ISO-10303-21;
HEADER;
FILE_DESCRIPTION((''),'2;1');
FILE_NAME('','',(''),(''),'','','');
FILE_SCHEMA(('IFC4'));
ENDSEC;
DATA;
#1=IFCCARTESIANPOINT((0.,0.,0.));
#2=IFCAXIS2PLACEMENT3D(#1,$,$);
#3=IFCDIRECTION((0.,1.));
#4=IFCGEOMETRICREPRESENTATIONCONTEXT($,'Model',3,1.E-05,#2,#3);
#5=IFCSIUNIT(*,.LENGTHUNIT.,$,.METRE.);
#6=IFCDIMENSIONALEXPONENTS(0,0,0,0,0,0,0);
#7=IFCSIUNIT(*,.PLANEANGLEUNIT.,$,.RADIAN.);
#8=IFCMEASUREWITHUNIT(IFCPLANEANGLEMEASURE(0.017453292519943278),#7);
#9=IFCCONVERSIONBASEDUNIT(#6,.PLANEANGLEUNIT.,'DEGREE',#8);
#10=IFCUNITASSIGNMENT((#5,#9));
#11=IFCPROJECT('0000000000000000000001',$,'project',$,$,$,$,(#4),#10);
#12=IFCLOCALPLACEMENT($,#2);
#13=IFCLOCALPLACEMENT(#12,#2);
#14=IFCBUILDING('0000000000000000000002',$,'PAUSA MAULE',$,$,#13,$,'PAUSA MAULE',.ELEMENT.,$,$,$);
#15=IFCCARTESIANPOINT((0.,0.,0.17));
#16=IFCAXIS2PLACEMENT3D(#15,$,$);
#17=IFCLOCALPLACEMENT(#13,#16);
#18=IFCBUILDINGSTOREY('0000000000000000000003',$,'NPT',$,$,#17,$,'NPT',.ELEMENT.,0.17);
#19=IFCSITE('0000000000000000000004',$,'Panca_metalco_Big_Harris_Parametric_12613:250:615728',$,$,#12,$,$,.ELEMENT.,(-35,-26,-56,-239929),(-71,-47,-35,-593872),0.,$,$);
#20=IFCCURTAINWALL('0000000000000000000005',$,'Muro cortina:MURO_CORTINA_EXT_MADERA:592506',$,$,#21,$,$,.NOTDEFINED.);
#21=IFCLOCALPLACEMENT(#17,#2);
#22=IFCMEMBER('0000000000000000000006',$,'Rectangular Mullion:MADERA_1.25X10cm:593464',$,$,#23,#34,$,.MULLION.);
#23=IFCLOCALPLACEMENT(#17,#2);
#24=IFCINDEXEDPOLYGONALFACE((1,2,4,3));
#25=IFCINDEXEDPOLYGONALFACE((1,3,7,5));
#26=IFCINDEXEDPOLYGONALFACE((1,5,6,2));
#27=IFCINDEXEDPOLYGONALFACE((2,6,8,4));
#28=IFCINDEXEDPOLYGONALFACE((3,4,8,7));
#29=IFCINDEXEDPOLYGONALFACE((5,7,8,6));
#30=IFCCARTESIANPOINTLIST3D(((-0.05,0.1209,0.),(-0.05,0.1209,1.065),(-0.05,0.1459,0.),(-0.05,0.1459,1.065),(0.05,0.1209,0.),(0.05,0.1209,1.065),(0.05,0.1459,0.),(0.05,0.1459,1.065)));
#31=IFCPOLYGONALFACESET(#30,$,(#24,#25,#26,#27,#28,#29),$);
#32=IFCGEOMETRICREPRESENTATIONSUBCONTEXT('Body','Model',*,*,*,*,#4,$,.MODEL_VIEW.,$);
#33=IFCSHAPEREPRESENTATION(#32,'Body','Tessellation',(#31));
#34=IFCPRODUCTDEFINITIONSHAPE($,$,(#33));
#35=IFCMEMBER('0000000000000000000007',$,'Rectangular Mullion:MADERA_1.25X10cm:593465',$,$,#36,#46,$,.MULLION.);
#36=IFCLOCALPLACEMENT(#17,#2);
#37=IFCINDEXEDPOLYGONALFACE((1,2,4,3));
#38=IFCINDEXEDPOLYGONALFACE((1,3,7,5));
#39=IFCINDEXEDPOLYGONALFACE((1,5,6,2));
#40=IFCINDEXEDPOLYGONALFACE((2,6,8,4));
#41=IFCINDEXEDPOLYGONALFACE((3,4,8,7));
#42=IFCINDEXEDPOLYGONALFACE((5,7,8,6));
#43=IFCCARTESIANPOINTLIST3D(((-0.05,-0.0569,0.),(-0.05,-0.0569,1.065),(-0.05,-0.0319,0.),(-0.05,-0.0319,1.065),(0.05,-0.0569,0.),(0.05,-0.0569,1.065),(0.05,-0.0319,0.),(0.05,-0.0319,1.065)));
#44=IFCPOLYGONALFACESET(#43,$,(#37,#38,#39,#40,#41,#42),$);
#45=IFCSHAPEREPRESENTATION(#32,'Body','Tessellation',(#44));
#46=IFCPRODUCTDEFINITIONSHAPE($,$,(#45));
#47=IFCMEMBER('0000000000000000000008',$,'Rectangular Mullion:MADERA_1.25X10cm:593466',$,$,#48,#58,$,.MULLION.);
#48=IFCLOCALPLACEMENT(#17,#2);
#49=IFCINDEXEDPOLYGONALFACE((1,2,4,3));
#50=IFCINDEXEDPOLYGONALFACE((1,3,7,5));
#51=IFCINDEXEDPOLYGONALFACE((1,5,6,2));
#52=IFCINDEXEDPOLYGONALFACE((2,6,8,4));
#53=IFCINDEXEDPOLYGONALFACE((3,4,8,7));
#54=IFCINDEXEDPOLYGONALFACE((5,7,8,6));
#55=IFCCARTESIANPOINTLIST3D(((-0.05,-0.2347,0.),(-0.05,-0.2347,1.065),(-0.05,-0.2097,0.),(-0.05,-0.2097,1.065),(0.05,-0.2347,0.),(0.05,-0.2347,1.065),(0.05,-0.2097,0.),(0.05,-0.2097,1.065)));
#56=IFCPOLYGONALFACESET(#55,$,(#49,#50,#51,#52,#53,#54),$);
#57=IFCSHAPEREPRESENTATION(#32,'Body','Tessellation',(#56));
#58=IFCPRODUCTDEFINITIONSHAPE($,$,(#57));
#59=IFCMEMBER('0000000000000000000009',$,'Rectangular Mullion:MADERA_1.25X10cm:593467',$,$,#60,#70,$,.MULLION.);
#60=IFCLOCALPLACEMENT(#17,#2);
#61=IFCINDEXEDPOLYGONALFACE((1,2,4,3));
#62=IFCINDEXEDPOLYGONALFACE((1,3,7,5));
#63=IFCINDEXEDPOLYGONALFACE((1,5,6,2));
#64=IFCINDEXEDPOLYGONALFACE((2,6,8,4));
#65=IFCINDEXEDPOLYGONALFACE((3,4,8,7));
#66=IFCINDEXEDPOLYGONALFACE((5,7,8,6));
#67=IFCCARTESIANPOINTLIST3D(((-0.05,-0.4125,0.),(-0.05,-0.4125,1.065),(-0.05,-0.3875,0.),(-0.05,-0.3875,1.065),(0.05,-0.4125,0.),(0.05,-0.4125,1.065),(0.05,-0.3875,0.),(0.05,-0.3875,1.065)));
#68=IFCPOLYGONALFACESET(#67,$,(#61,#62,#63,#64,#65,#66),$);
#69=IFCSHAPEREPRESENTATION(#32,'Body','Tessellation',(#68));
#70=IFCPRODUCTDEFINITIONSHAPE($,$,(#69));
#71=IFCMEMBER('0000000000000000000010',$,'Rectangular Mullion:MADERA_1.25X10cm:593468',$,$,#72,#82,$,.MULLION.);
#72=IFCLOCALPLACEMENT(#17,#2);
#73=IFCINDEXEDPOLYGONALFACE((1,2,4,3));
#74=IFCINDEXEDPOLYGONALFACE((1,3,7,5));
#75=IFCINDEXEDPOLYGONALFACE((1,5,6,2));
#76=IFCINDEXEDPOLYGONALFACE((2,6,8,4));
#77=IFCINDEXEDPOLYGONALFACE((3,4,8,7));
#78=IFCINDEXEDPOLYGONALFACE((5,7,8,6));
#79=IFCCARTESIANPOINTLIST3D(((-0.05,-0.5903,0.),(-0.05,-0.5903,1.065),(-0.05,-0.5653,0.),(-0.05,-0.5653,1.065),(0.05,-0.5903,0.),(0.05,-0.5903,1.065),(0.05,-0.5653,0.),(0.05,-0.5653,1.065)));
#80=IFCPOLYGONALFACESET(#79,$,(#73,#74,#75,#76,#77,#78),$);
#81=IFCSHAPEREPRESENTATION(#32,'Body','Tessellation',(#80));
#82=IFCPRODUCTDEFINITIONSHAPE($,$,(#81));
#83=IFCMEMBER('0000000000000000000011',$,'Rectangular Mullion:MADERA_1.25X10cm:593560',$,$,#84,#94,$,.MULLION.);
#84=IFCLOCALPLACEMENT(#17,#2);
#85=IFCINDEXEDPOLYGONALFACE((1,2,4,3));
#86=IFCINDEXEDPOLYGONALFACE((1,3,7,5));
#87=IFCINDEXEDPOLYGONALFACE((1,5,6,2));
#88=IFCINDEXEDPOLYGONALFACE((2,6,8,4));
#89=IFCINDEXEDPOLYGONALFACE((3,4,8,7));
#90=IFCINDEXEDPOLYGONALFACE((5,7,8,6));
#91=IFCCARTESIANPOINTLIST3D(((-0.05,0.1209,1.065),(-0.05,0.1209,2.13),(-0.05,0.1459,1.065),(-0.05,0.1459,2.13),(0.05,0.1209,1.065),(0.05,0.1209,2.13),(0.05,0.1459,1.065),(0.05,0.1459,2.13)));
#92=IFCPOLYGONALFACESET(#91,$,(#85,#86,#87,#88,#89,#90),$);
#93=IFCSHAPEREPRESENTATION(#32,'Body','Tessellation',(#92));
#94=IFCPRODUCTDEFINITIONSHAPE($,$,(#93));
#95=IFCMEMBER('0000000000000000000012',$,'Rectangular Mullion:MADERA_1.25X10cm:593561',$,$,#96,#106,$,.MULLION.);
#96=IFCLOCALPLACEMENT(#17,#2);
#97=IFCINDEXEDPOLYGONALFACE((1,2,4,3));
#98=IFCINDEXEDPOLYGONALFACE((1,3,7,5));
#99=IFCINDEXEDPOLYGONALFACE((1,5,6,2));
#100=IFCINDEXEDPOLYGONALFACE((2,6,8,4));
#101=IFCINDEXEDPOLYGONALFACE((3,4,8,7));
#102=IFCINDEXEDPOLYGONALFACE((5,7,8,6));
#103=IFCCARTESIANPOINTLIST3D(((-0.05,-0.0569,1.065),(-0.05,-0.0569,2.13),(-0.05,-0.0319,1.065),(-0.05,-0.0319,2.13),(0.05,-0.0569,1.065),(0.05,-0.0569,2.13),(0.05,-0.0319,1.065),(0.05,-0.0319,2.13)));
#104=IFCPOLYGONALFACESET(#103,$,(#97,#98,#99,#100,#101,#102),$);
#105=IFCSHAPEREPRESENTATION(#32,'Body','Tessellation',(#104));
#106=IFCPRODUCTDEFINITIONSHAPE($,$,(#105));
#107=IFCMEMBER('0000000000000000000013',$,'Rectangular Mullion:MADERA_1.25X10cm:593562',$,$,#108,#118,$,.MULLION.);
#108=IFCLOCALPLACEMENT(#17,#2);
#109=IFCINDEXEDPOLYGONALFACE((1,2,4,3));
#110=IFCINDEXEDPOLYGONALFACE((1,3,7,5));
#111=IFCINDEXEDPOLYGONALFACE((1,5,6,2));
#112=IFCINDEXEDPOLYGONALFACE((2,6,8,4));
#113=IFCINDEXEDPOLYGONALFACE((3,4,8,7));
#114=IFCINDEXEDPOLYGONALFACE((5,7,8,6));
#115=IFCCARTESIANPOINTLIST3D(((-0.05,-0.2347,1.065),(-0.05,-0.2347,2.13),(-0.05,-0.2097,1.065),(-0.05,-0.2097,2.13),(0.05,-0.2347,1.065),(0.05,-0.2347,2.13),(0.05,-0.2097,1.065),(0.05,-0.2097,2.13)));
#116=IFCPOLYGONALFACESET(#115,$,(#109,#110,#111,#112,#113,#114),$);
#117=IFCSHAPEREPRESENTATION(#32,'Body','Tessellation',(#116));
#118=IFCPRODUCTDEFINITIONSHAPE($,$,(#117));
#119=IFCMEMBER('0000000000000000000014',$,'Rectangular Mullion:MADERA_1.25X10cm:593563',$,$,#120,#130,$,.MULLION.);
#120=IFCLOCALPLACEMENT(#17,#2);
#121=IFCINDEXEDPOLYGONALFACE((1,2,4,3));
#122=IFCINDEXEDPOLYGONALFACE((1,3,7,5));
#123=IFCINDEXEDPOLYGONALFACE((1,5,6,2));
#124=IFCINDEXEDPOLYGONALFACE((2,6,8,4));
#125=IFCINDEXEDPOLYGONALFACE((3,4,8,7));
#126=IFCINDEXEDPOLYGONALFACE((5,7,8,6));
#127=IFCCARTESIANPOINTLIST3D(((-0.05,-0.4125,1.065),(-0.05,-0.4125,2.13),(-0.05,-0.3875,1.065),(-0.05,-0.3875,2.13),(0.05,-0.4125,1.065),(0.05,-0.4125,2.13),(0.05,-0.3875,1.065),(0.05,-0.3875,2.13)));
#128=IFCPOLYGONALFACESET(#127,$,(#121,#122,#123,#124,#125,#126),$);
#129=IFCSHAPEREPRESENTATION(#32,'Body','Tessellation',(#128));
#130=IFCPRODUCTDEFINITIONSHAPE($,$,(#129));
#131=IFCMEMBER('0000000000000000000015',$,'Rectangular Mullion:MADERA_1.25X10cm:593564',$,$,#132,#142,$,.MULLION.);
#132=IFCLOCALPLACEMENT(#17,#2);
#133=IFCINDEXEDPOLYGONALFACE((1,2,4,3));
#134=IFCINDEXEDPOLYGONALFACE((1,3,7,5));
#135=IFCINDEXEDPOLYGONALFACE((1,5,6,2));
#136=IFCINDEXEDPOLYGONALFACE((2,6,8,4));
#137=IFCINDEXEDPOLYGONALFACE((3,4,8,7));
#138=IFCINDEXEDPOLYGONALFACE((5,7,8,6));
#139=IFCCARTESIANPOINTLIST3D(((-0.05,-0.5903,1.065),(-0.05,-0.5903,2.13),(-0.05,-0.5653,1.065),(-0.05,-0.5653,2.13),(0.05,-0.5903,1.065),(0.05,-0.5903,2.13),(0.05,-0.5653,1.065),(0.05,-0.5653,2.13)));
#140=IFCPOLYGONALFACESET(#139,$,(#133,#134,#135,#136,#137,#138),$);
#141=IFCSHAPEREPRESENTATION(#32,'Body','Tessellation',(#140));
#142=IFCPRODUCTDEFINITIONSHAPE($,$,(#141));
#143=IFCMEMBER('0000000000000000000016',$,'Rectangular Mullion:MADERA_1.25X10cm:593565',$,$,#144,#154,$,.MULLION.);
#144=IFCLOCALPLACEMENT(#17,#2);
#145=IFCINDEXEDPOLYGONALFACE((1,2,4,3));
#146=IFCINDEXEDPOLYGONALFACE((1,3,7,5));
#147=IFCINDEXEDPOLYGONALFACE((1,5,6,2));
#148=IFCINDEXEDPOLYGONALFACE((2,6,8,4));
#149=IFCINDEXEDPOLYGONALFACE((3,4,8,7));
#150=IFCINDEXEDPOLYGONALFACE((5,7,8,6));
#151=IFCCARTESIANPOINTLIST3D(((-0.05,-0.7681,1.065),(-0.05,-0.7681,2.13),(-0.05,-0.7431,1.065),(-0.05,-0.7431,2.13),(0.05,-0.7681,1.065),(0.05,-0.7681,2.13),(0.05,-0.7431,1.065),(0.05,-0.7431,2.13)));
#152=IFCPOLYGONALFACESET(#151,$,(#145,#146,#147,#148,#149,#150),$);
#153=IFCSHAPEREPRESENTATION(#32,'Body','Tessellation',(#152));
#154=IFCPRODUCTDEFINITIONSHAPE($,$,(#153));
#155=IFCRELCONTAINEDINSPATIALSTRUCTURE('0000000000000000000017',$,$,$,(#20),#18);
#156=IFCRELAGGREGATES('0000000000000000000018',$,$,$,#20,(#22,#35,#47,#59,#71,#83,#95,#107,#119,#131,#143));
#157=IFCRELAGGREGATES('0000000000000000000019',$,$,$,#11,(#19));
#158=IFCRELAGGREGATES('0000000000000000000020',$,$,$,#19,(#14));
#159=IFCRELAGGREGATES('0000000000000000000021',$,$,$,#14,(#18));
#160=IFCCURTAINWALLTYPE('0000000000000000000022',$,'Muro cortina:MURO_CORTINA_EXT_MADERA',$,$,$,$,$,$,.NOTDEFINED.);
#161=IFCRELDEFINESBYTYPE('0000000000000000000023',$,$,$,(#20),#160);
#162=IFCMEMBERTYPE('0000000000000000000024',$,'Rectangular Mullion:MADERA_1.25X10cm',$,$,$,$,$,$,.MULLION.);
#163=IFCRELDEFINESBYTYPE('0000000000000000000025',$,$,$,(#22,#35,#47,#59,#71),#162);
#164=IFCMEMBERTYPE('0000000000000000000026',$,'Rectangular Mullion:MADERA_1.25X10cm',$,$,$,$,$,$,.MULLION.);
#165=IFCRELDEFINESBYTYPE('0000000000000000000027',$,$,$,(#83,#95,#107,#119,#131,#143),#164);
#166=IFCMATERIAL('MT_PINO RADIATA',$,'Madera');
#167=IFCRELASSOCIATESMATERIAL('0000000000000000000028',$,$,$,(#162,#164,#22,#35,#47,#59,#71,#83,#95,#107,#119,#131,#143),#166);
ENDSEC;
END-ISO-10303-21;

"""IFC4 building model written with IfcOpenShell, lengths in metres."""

from ifc_helpers import new_model, entity, si_unit, converted_unit, direction, frame, frame_2d, origin, place, context, subcontext, project, spatial, rectangle, extrude, source, transform, mapped, material, material_profile, profile_set, profile_usage, type_object, type_shapes, element, aggregate, save


model = new_model("IFC4")

# Units and contexts
model_context = context("Model", 3, precision=1e-05, world=origin(), true_north=direction((0.0, 1.0)))
body_context = subcontext(model_context, "Body", "Model", "MODEL_VIEW")
ifc_project = project(units=[si_unit("LENGTHUNIT", "METRE"), converted_unit("PLANEANGLEUNIT", "DEGREE", entity("IfcPlaneAngleMeasure", 0.017453292519943278), si_unit("PLANEANGLEUNIT", "RADIAN"), dimensions=[0, 0, 0, 0, 0, 0, 0])], contexts=[model_context])

# Site, building, storey
site_placement = place(None, origin())
site = spatial("IfcSite", under=ifc_project, at=site_placement, Name="Panca_metalco_Big_Harris_Parametric_12613:250:615728", CompositionType="ELEMENT", RefLatitude=(-35, -26, -56, -239929), RefLongitude=(-71, -47, -35, -593872), RefElevation=0.0)
building_placement = place(site_placement, origin())
building = spatial("IfcBuilding", under=site, at=building_placement, Name="PAUSA MAULE", LongName="PAUSA MAULE", CompositionType="ELEMENT")
storey_placement = place(building_placement, frame((0.0, 0.0, 0.17)))
storey = spatial("IfcBuildingStorey", under=building, at=storey_placement, Name="NPT", LongName="NPT", CompositionType="ELEMENT", Elevation=0.17)

# Curtain wall, members
curtain_wall_type = type_object("IfcCurtainWallType", Name="Muro cortina:MURO_CORTINA_EXT_MADERA", PredefinedType="NOTDEFINED")
curtain_wall_placement = place(storey_placement, frame((0.0, 0.0, -0.17)))
curtain_wall = element("IfcCurtainWall", 1, at=curtain_wall_placement, inside=storey, type_object=curtain_wall_type, Name="Muro cortina:MURO_CORTINA_EXT_MADERA:592506", PredefinedType="NOTDEFINED")
ifc_material_1 = material(Name="MT_PINO RADIATA", Category="Madera")
ifc_material_profile = material_profile(ifc_material_1, rectangle(XDim=0.025, YDim=0.1, at=frame_2d((0.0, 0.0), x_axis=(1.0, 0.0))), Name="MADERA_1.25X10cm")
ifc_profile_set = profile_set([ifc_material_profile], Name="MADERA_1.25X10cm")
ifc_profile_usage = profile_usage(ifc_profile_set)
member_type_1 = type_object("IfcMemberType", Name="Rectangular Mullion:MADERA_1.25X10cm", PredefinedType="MULLION", material=ifc_profile_set)
shared_shape_1 = source(origin(), body_context, "Body", "SweptSolid", [
    extrude(rectangle(XDim=0.025, YDim=0.1, at=frame_2d((0.0, 0.0), x_axis=(1.0, 0.0))), frame((0.0, 0.0, -1.065), z_axis=(0.0, 0.0, 1.0), x_axis=(-1.0, 0.0, 0.0)), (0.0, 0.0, 1.0), 1.065),
])
type_shapes(member_type_1, [shared_shape_1])
member_1_placement = place(curtain_wall_placement, frame((0.0, 0.1334, 0.17), z_axis=(0.0, 0.0, -1.0), x_axis=(0.0, -1.0, 0.0)))
member_1 = element("IfcMember", 2, at=member_1_placement, type_object=member_type_1, material=ifc_profile_usage, Name="Rectangular Mullion:MADERA_1.25X10cm:593464", PredefinedType="MULLION", context=body_context, shape_type="MappedRepresentation", body=[
    mapped(shared_shape_1, transform((0.0, 0.0, 0.0), scale=1.0)),
])
member_2_placement = place(curtain_wall_placement, frame((0.0, -0.0444, 0.17), z_axis=(0.0, 0.0, -1.0), x_axis=(0.0, -1.0, 0.0)))
member_2 = element("IfcMember", 3, at=member_2_placement, type_object=member_type_1, material=ifc_profile_usage, Name="Rectangular Mullion:MADERA_1.25X10cm:593465", PredefinedType="MULLION", context=body_context, shape_type="MappedRepresentation", body=[
    mapped(shared_shape_1, transform((0.0, 0.0, 0.0), scale=1.0)),
])
member_3_placement = place(curtain_wall_placement, frame((0.0, -0.2222, 0.17), z_axis=(0.0, 0.0, -1.0), x_axis=(0.0, -1.0, 0.0)))
member_3 = element("IfcMember", 4, at=member_3_placement, type_object=member_type_1, material=ifc_profile_usage, Name="Rectangular Mullion:MADERA_1.25X10cm:593466", PredefinedType="MULLION", context=body_context, shape_type="MappedRepresentation", body=[
    mapped(shared_shape_1, transform((0.0, 0.0, 0.0), scale=1.0)),
])
member_4_placement = place(curtain_wall_placement, frame((0.0, -0.4, 0.17), z_axis=(0.0, 0.0, -1.0), x_axis=(0.0, -1.0, 0.0)))
member_4 = element("IfcMember", 5, at=member_4_placement, type_object=member_type_1, material=ifc_profile_usage, Name="Rectangular Mullion:MADERA_1.25X10cm:593467", PredefinedType="MULLION", context=body_context, shape_type="MappedRepresentation", body=[
    mapped(shared_shape_1, transform((0.0, 0.0, 0.0), scale=1.0)),
])
member_5_placement = place(curtain_wall_placement, frame((0.0, -0.5778, 0.17), z_axis=(0.0, 0.0, -1.0), x_axis=(0.0, -1.0, 0.0)))
member_5 = element("IfcMember", 6, at=member_5_placement, type_object=member_type_1, material=ifc_profile_usage, Name="Rectangular Mullion:MADERA_1.25X10cm:593468", PredefinedType="MULLION", context=body_context, shape_type="MappedRepresentation", body=[
    mapped(shared_shape_1, transform((0.0, 0.0, 0.0), scale=1.0)),
])
member_type_2 = type_object("IfcMemberType", Name="Rectangular Mullion:MADERA_1.25X10cm", PredefinedType="MULLION", material=ifc_profile_set)
shared_shape_2 = source(origin(), body_context, "Body", "SweptSolid", [
    extrude(rectangle(XDim=0.025, YDim=0.1, at=frame_2d((0.0, 0.0), x_axis=(1.0, 0.0))), frame((0.0, 0.0, -1.065), z_axis=(0.0, 0.0, 1.0), x_axis=(-1.0, 0.0, 0.0)), (0.0, 0.0, 1.0), 1.065),
])
type_shapes(member_type_2, [shared_shape_2])
member_6_placement = place(curtain_wall_placement, frame((0.0, 0.1334, 1.235), z_axis=(0.0, 0.0, -1.0), x_axis=(0.0, -1.0, 0.0)))
member_6 = element("IfcMember", 7, at=member_6_placement, type_object=member_type_2, material=ifc_profile_usage, Name="Rectangular Mullion:MADERA_1.25X10cm:593560", PredefinedType="MULLION", context=body_context, shape_type="MappedRepresentation", body=[
    mapped(shared_shape_2, transform((0.0, 0.0, 0.0), scale=1.0)),
])
member_7_placement = place(curtain_wall_placement, frame((0.0, -0.0444, 1.235), z_axis=(0.0, 0.0, -1.0), x_axis=(0.0, -1.0, 0.0)))
member_7 = element("IfcMember", 8, at=member_7_placement, type_object=member_type_2, material=ifc_profile_usage, Name="Rectangular Mullion:MADERA_1.25X10cm:593561", PredefinedType="MULLION", context=body_context, shape_type="MappedRepresentation", body=[
    mapped(shared_shape_2, transform((0.0, 0.0, 0.0), scale=1.0)),
])
member_8_placement = place(curtain_wall_placement, frame((0.0, -0.2222, 1.235), z_axis=(0.0, 0.0, -1.0), x_axis=(0.0, -1.0, 0.0)))
member_8 = element("IfcMember", 9, at=member_8_placement, type_object=member_type_2, material=ifc_profile_usage, Name="Rectangular Mullion:MADERA_1.25X10cm:593562", PredefinedType="MULLION", context=body_context, shape_type="MappedRepresentation", body=[
    mapped(shared_shape_2, transform((0.0, 0.0, 0.0), scale=1.0)),
])
member_9_placement = place(curtain_wall_placement, frame((0.0, -0.4, 1.235), z_axis=(0.0, 0.0, -1.0), x_axis=(0.0, -1.0, 0.0)))
member_9 = element("IfcMember", 10, at=member_9_placement, type_object=member_type_2, material=ifc_profile_usage, Name="Rectangular Mullion:MADERA_1.25X10cm:593563", PredefinedType="MULLION", context=body_context, shape_type="MappedRepresentation", body=[
    mapped(shared_shape_2, transform((0.0, 0.0, 0.0), scale=1.0)),
])
member_10_placement = place(curtain_wall_placement, frame((0.0, -0.5778, 1.235), z_axis=(0.0, 0.0, -1.0), x_axis=(0.0, -1.0, 0.0)))
member_10 = element("IfcMember", 11, at=member_10_placement, type_object=member_type_2, material=ifc_profile_usage, Name="Rectangular Mullion:MADERA_1.25X10cm:593564", PredefinedType="MULLION", context=body_context, shape_type="MappedRepresentation", body=[
    mapped(shared_shape_2, transform((0.0, 0.0, 0.0), scale=1.0)),
])
member_11_placement = place(curtain_wall_placement, frame((0.0, -0.7556, 1.235), z_axis=(0.0, 0.0, -1.0), x_axis=(0.0, -1.0, 0.0)))
member_11 = element("IfcMember", 12, at=member_11_placement, type_object=member_type_2, material=ifc_profile_usage, Name="Rectangular Mullion:MADERA_1.25X10cm:593565", PredefinedType="MULLION", context=body_context, shape_type="MappedRepresentation", body=[
    mapped(shared_shape_2, transform((0.0, 0.0, 0.0), scale=1.0)),
])
aggregate(curtain_wall, [member_1, member_2, member_3, member_4, member_5, member_6, member_7, member_8, member_9, member_10, member_11])

save(model, "model.ifc")
